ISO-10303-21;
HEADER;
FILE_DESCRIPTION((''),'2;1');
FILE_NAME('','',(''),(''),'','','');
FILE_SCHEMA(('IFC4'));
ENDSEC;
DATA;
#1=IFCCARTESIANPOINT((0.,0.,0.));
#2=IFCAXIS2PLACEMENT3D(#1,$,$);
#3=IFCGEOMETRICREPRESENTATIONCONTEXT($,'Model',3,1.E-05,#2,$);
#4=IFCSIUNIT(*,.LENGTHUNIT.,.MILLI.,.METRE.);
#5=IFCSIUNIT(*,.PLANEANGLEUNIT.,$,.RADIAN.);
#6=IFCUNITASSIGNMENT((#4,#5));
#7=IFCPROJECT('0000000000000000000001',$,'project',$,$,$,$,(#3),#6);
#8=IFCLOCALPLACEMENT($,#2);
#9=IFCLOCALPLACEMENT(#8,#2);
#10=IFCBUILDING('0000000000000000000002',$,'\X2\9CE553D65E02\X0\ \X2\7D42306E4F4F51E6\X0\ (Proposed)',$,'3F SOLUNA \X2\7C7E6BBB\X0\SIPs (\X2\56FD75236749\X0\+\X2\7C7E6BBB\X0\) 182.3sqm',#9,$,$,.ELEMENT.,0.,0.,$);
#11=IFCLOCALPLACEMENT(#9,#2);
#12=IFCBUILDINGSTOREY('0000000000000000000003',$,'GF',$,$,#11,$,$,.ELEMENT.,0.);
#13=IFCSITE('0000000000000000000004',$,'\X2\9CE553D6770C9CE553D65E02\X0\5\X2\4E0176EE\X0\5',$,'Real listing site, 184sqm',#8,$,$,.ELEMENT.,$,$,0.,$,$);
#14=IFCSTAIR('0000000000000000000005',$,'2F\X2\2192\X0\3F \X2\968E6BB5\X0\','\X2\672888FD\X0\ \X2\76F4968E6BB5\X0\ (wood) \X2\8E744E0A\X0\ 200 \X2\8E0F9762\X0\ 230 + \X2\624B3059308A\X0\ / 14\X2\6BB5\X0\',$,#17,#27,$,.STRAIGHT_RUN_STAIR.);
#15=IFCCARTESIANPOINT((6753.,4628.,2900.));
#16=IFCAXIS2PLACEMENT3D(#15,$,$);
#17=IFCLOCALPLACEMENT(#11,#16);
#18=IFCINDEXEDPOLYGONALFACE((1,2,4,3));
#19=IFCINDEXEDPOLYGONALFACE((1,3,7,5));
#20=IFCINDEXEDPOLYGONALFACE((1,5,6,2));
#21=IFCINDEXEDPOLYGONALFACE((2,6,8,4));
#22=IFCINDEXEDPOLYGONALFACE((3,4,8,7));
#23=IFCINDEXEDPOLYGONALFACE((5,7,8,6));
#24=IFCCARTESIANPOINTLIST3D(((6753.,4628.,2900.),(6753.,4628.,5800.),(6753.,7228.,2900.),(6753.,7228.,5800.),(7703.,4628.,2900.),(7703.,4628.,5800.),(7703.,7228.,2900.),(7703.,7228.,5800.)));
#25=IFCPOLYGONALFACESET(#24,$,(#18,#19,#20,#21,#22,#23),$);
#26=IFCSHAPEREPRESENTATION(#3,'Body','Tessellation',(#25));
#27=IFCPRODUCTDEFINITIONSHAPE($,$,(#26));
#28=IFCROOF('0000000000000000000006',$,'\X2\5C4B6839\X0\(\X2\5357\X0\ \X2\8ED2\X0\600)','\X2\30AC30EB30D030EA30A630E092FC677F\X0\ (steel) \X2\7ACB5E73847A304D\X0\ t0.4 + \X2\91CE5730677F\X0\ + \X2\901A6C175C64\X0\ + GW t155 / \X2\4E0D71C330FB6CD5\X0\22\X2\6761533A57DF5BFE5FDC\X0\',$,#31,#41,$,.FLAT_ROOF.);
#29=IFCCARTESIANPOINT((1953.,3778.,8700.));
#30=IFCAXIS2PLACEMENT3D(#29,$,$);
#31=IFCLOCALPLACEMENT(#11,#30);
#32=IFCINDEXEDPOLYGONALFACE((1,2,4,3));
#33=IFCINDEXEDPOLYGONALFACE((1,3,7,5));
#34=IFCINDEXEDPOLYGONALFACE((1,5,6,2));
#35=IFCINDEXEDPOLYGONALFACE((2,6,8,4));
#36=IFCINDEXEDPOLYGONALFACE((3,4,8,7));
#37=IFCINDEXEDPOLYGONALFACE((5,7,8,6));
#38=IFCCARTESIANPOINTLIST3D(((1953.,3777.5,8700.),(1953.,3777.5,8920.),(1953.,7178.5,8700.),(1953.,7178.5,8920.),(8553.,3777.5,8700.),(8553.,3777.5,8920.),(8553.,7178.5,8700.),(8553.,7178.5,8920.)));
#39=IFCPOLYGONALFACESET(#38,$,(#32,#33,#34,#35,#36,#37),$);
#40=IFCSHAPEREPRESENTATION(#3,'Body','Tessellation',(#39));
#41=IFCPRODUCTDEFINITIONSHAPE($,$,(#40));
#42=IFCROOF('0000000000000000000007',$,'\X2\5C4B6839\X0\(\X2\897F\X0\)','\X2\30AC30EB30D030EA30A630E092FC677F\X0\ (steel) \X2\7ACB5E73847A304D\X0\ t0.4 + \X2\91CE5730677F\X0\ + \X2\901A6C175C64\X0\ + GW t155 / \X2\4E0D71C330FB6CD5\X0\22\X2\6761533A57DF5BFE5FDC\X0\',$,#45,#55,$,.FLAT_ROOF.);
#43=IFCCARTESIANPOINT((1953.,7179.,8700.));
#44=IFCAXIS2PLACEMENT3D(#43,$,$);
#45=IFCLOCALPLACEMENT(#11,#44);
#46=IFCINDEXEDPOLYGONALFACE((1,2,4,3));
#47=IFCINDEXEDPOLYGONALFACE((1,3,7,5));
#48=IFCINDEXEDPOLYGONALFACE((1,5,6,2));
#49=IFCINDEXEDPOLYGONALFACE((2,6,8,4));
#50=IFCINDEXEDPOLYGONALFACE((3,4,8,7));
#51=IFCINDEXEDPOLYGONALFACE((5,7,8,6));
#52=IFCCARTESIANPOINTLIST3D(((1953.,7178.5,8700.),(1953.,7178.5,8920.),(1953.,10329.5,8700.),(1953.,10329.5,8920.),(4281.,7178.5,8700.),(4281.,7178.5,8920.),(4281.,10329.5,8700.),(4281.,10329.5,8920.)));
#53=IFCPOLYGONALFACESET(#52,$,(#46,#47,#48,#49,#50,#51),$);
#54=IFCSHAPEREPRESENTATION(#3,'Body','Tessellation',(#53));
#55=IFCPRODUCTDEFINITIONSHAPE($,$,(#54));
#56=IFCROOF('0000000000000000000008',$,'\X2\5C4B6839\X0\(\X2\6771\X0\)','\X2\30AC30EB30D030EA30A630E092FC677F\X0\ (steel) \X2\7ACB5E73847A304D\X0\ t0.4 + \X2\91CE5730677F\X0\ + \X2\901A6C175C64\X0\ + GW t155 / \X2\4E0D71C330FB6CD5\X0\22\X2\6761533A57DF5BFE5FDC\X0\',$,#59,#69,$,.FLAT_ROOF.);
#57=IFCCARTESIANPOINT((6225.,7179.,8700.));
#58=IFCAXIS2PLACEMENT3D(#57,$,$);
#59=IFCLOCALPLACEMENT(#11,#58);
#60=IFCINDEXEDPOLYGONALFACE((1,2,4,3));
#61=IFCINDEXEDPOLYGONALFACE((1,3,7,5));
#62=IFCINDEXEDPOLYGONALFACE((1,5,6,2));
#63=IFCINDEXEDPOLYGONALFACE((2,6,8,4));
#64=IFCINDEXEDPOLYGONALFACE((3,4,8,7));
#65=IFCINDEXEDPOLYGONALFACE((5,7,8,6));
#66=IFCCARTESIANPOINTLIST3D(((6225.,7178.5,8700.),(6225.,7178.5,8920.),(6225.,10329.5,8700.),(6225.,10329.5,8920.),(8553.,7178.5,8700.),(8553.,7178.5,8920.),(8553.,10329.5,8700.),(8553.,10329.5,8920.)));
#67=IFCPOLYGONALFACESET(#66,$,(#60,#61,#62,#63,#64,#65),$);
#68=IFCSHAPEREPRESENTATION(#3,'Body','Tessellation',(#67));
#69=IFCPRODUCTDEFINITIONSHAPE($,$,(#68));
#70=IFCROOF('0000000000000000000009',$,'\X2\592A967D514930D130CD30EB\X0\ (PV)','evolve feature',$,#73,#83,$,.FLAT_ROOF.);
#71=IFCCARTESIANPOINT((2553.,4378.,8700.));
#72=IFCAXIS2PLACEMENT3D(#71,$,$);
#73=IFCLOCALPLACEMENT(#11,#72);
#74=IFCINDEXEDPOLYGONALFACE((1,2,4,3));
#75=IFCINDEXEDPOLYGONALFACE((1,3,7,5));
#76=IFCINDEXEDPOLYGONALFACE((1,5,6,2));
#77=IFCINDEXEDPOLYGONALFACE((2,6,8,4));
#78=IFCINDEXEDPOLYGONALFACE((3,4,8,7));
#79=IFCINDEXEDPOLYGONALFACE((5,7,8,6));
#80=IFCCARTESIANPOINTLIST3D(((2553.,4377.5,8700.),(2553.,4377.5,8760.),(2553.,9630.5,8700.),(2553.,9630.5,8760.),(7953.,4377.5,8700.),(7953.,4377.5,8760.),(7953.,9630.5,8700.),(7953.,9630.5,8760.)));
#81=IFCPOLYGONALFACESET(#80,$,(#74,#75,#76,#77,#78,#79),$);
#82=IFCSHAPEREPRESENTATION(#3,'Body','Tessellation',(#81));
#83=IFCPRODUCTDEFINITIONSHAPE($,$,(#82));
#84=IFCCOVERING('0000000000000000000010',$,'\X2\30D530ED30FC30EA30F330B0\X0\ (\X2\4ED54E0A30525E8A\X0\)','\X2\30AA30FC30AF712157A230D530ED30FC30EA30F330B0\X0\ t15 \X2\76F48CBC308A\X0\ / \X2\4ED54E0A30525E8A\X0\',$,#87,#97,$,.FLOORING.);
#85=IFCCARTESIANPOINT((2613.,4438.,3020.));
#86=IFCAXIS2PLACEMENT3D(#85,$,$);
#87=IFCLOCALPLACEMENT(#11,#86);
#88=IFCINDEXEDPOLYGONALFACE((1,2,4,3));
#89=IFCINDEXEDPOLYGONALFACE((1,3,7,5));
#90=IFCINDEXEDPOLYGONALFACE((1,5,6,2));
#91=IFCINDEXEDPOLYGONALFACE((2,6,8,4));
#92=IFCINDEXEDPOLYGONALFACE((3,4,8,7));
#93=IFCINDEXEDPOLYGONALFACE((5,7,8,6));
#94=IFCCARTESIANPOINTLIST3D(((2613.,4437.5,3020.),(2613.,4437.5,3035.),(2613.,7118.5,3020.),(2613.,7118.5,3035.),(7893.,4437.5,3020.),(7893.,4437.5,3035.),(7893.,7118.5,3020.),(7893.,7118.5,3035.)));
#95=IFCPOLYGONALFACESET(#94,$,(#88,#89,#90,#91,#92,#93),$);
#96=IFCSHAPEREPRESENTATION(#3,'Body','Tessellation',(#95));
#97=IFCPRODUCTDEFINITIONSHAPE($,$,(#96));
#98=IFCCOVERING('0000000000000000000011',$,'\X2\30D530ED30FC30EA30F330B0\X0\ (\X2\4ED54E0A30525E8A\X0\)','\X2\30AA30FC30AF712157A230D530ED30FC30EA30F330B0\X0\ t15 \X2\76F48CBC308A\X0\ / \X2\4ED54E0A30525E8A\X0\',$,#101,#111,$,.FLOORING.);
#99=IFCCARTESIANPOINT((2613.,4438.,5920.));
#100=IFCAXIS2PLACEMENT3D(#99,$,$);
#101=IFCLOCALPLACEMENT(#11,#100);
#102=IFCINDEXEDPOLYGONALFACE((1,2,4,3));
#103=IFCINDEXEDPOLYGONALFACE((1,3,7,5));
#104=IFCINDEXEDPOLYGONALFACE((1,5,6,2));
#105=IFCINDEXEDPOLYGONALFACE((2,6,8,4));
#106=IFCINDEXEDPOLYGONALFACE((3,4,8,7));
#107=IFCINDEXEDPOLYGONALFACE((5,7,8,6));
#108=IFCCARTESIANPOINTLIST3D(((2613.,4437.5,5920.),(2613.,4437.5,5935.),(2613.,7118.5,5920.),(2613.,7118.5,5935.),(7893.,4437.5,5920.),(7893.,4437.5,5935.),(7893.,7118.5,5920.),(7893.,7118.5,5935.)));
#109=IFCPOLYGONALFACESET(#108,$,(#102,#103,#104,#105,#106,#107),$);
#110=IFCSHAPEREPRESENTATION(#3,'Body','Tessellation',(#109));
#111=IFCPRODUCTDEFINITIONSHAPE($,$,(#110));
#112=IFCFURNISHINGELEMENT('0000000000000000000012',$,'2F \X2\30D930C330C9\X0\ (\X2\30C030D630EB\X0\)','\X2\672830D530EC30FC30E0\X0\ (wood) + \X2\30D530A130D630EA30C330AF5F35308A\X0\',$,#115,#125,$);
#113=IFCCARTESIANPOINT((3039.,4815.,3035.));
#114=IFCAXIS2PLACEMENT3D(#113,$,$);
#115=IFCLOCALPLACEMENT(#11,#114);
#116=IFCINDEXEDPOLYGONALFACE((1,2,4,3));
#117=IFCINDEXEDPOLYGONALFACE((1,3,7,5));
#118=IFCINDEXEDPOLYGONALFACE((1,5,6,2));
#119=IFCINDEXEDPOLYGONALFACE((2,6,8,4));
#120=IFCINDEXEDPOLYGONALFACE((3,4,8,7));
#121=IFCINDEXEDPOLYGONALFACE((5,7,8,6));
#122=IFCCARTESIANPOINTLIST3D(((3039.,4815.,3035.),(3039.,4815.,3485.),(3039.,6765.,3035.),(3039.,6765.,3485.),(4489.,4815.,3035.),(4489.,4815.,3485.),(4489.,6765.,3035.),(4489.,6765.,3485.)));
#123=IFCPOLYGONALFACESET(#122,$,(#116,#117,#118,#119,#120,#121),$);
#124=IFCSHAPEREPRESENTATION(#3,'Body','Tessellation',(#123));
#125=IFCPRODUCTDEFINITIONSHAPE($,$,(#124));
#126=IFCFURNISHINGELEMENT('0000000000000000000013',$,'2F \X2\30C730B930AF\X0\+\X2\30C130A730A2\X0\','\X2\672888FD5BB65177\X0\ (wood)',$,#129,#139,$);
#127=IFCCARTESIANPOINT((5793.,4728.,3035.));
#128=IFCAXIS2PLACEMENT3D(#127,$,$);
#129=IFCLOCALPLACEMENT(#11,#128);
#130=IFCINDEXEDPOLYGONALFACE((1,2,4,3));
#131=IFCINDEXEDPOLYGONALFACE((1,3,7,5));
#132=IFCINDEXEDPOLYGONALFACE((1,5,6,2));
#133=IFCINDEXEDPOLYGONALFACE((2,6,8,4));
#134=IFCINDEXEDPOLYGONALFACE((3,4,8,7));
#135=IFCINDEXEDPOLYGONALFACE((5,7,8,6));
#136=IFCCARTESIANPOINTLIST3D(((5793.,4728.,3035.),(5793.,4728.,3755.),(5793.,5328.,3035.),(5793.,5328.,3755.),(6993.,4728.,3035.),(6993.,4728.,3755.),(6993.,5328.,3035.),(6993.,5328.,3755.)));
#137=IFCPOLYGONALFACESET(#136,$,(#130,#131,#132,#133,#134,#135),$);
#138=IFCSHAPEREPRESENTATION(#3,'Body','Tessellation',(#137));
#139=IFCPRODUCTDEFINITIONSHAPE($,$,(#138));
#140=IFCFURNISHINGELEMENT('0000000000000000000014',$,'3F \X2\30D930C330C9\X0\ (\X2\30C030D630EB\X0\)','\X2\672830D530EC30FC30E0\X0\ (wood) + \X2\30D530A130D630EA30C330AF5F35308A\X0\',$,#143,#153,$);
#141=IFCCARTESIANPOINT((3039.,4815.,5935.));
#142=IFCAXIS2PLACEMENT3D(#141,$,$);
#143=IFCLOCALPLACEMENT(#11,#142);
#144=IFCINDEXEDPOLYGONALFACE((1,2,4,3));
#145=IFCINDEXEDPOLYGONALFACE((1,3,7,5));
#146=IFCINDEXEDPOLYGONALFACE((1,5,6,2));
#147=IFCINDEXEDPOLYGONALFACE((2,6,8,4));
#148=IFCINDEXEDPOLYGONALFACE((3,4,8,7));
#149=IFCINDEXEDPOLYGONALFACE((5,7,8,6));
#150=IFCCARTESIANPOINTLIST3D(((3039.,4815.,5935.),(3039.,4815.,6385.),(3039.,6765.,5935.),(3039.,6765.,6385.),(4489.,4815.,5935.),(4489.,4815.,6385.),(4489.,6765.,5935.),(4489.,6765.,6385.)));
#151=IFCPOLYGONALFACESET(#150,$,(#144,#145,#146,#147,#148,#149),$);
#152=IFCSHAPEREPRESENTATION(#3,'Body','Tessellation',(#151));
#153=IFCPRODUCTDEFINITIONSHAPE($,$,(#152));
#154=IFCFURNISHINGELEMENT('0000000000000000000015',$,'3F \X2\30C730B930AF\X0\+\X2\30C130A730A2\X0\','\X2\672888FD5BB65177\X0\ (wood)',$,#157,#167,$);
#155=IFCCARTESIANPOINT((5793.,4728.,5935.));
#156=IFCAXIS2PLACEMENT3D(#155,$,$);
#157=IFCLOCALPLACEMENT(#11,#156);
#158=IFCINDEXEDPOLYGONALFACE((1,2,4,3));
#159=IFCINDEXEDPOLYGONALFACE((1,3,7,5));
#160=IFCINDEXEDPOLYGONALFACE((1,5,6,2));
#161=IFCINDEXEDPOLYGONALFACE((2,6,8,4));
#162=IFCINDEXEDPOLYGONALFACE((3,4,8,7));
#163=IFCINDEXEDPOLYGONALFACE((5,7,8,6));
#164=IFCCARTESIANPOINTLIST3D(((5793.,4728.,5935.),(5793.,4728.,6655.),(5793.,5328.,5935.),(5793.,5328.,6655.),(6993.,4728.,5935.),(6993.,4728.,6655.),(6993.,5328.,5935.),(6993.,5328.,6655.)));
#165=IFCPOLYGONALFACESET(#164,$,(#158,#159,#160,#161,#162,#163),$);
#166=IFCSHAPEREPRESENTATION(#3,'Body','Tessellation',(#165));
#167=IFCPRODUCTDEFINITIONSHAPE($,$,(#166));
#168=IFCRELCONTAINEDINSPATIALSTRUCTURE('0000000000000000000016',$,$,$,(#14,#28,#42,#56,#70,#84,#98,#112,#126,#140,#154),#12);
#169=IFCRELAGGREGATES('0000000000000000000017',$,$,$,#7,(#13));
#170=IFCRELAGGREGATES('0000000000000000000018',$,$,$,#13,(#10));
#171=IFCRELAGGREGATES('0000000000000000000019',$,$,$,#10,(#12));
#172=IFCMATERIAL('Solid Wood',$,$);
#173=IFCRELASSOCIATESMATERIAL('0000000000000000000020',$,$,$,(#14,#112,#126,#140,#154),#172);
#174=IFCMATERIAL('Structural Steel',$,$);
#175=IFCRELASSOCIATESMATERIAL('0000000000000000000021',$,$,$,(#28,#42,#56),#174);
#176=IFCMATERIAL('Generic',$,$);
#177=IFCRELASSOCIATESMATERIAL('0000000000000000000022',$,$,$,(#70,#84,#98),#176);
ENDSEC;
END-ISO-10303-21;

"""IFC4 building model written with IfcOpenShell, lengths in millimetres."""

from ifc_helpers import new_model, si_unit, frame, frame_2d, origin, place, context, project, spatial, rectangle, extrude, material, element, save


model = new_model("IFC4")

# Units and contexts
model_context = context("Model", 3, precision=1e-05, world=origin())
ifc_project = project(units=[si_unit("LENGTHUNIT", "METRE", prefix="MILLI"), si_unit("PLANEANGLEUNIT", "RADIAN")], contexts=[model_context])

# Site, building, storey
site_placement = place(None, origin())
site = spatial("IfcSite", under=ifc_project, at=site_placement, Name="鳥取県鳥取市5丁目5", ObjectType="Real listing site, 184sqm", CompositionType="ELEMENT", RefElevation=0.0)
building_placement = place(site_placement, origin())
building = spatial("IfcBuilding", under=site, at=building_placement, Name="鳥取市 終の住処 (Proposed)", ObjectType="3F SOLUNA 籾殻SIPs (国産杉+籾殻) 182.3sqm", CompositionType="ELEMENT", ElevationOfRefHeight=0.0, ElevationOfTerrain=0.0)
storey_placement = place(building_placement, origin())
storey = spatial("IfcBuildingStorey", under=building, at=storey_placement, Name="GF", CompositionType="ELEMENT", Elevation=0.0)

# Shared definitions
ifc_material_1 = material(Name="Solid Wood")

# Stair
stair_placement = place(storey_placement, frame((6753.0, 4628.0, 2900.0)))
element("IfcStair", 1, at=stair_placement, inside=storey, material=ifc_material_1, Name="2F→3F 階段", Description="木製 直階段 (wood) 蹴上 200 踏面 230 + 手すり / 14段", PredefinedType="STRAIGHT_RUN_STAIR", context=model_context, shape_type="SweptSolid", body=[
    extrude(rectangle(XDim=950.0, YDim=2600.0, at=frame_2d((475.0, 1300.0))), frame((6753.0, 4628.0, 2900.0)), (0.0, 0.0, 1.0), 2900.0),
])

# Roofs
ifc_material_2 = material(Name="Structural Steel")
roof_1_placement = place(storey_placement, frame((1953.0, 3778.0, 8700.0)))
element("IfcRoof", 2, at=roof_1_placement, inside=storey, material=ifc_material_2, Name="屋根(南 軒600)", Description="ガルバリウム鋼板 (steel) 立平葺き t0.4 + 野地板 + 通気層 + GW t155 / 不燃・法22条区域対応", PredefinedType="FLAT_ROOF", context=model_context, shape_type="SweptSolid", body=[
    extrude(rectangle(XDim=6600.0, YDim=3401.0, at=frame_2d((3300.0, 1700.0))), frame((1953.0, 3778.0, 8700.0)), (0.0, 0.0, 1.0), 220.0),
])
roof_2_placement = place(storey_placement, frame((1953.0, 7179.0, 8700.0)))
element("IfcRoof", 3, at=roof_2_placement, inside=storey, material=ifc_material_2, Name="屋根(西)", Description="ガルバリウム鋼板 (steel) 立平葺き t0.4 + 野地板 + 通気層 + GW t155 / 不燃・法22条区域対応", PredefinedType="FLAT_ROOF", context=model_context, shape_type="SweptSolid", body=[
    extrude(rectangle(XDim=2328.0, YDim=3151.0, at=frame_2d((1164.0, 1575.0))), frame((1953.0, 7179.0, 8700.0)), (0.0, 0.0, 1.0), 220.0),
])
roof_3_placement = place(storey_placement, frame((6225.0, 7179.0, 8700.0)))
element("IfcRoof", 4, at=roof_3_placement, inside=storey, material=ifc_material_2, Name="屋根(東)", Description="ガルバリウム鋼板 (steel) 立平葺き t0.4 + 野地板 + 通気層 + GW t155 / 不燃・法22条区域対応", PredefinedType="FLAT_ROOF", context=model_context, shape_type="SweptSolid", body=[
    extrude(rectangle(XDim=2328.0, YDim=3151.0, at=frame_2d((1164.0, 1575.0))), frame((6225.0, 7179.0, 8700.0)), (0.0, 0.0, 1.0), 220.0),
])
ifc_material_3 = material(Name="Generic")
roof_4_placement = place(storey_placement, frame((2553.0, 4378.0, 8700.0)))
element("IfcRoof", 5, at=roof_4_placement, inside=storey, material=ifc_material_3, Name="太陽光パネル (PV)", Description="evolve feature", PredefinedType="FLAT_ROOF", context=model_context, shape_type="SweptSolid", body=[
    extrude(rectangle(XDim=5400.0, YDim=5253.0, at=frame_2d((2700.0, 2626.0))), frame((2553.0, 4378.0, 8700.0)), (0.0, 0.0, 1.0), 60.0),
])

# Coverings
covering_1_placement = place(storey_placement, frame((2613.0, 4438.0, 3020.0)))
element("IfcCovering", 6, at=covering_1_placement, inside=storey, material=ifc_material_3, Name="フローリング (仕上げ床)", Description="オーク無垢フローリング t15 直貼り / 仕上げ床", PredefinedType="FLOORING", context=model_context, shape_type="SweptSolid", body=[
    extrude(rectangle(XDim=5280.0, YDim=2681.0, at=frame_2d((2640.0, 1340.0))), frame((2613.0, 4438.0, 3020.0)), (0.0, 0.0, 1.0), 15.0),
])
covering_2_placement = place(storey_placement, frame((2613.0, 4438.0, 5920.0)))
element("IfcCovering", 7, at=covering_2_placement, inside=storey, material=ifc_material_3, Name="フローリング (仕上げ床)", Description="オーク無垢フローリング t15 直貼り / 仕上げ床", PredefinedType="FLOORING", context=model_context, shape_type="SweptSolid", body=[
    extrude(rectangle(XDim=5280.0, YDim=2681.0, at=frame_2d((2640.0, 1340.0))), frame((2613.0, 4438.0, 5920.0)), (0.0, 0.0, 1.0), 15.0),
])

# Furnishing elements
furnishing_1_placement = place(storey_placement, frame((3039.0, 4815.0, 3035.0)))
element("IfcFurnishingElement", 8, at=furnishing_1_placement, inside=storey, material=ifc_material_1, Name="2F ベッド (ダブル)", Description="木フレーム (wood) + ファブリック張り", context=model_context, shape_type="SweptSolid", body=[
    extrude(rectangle(XDim=1450.0, YDim=1950.0, at=frame_2d((725.0, 975.0))), frame((3039.0, 4815.0, 3035.0)), (0.0, 0.0, 1.0), 450.0),
])
furnishing_2_placement = place(storey_placement, frame((5793.0, 4728.0, 3035.0)))
element("IfcFurnishingElement", 9, at=furnishing_2_placement, inside=storey, material=ifc_material_1, Name="2F デスク+チェア", Description="木製家具 (wood)", context=model_context, shape_type="SweptSolid", body=[
    extrude(rectangle(XDim=1200.0, YDim=600.0, at=frame_2d((600.0, 300.0))), frame((5793.0, 4728.0, 3035.0)), (0.0, 0.0, 1.0), 720.0),
])
furnishing_3_placement = place(storey_placement, frame((3039.0, 4815.0, 5935.0)))
element("IfcFurnishingElement", 10, at=furnishing_3_placement, inside=storey, material=ifc_material_1, Name="3F ベッド (ダブル)", Description="木フレーム (wood) + ファブリック張り", context=model_context, shape_type="SweptSolid", body=[
    extrude(rectangle(XDim=1450.0, YDim=1950.0, at=frame_2d((725.0, 975.0))), frame((3039.0, 4815.0, 5935.0)), (0.0, 0.0, 1.0), 450.0),
])
furnishing_4_placement = place(storey_placement, frame((5793.0, 4728.0, 5935.0)))
element("IfcFurnishingElement", 11, at=furnishing_4_placement, inside=storey, material=ifc_material_1, Name="3F デスク+チェア", Description="木製家具 (wood)", context=model_context, shape_type="SweptSolid", body=[
    extrude(rectangle(XDim=1200.0, YDim=600.0, at=frame_2d((600.0, 300.0))), frame((5793.0, 4728.0, 5935.0)), (0.0, 0.0, 1.0), 720.0),
])

save(model, "model.ifc")
